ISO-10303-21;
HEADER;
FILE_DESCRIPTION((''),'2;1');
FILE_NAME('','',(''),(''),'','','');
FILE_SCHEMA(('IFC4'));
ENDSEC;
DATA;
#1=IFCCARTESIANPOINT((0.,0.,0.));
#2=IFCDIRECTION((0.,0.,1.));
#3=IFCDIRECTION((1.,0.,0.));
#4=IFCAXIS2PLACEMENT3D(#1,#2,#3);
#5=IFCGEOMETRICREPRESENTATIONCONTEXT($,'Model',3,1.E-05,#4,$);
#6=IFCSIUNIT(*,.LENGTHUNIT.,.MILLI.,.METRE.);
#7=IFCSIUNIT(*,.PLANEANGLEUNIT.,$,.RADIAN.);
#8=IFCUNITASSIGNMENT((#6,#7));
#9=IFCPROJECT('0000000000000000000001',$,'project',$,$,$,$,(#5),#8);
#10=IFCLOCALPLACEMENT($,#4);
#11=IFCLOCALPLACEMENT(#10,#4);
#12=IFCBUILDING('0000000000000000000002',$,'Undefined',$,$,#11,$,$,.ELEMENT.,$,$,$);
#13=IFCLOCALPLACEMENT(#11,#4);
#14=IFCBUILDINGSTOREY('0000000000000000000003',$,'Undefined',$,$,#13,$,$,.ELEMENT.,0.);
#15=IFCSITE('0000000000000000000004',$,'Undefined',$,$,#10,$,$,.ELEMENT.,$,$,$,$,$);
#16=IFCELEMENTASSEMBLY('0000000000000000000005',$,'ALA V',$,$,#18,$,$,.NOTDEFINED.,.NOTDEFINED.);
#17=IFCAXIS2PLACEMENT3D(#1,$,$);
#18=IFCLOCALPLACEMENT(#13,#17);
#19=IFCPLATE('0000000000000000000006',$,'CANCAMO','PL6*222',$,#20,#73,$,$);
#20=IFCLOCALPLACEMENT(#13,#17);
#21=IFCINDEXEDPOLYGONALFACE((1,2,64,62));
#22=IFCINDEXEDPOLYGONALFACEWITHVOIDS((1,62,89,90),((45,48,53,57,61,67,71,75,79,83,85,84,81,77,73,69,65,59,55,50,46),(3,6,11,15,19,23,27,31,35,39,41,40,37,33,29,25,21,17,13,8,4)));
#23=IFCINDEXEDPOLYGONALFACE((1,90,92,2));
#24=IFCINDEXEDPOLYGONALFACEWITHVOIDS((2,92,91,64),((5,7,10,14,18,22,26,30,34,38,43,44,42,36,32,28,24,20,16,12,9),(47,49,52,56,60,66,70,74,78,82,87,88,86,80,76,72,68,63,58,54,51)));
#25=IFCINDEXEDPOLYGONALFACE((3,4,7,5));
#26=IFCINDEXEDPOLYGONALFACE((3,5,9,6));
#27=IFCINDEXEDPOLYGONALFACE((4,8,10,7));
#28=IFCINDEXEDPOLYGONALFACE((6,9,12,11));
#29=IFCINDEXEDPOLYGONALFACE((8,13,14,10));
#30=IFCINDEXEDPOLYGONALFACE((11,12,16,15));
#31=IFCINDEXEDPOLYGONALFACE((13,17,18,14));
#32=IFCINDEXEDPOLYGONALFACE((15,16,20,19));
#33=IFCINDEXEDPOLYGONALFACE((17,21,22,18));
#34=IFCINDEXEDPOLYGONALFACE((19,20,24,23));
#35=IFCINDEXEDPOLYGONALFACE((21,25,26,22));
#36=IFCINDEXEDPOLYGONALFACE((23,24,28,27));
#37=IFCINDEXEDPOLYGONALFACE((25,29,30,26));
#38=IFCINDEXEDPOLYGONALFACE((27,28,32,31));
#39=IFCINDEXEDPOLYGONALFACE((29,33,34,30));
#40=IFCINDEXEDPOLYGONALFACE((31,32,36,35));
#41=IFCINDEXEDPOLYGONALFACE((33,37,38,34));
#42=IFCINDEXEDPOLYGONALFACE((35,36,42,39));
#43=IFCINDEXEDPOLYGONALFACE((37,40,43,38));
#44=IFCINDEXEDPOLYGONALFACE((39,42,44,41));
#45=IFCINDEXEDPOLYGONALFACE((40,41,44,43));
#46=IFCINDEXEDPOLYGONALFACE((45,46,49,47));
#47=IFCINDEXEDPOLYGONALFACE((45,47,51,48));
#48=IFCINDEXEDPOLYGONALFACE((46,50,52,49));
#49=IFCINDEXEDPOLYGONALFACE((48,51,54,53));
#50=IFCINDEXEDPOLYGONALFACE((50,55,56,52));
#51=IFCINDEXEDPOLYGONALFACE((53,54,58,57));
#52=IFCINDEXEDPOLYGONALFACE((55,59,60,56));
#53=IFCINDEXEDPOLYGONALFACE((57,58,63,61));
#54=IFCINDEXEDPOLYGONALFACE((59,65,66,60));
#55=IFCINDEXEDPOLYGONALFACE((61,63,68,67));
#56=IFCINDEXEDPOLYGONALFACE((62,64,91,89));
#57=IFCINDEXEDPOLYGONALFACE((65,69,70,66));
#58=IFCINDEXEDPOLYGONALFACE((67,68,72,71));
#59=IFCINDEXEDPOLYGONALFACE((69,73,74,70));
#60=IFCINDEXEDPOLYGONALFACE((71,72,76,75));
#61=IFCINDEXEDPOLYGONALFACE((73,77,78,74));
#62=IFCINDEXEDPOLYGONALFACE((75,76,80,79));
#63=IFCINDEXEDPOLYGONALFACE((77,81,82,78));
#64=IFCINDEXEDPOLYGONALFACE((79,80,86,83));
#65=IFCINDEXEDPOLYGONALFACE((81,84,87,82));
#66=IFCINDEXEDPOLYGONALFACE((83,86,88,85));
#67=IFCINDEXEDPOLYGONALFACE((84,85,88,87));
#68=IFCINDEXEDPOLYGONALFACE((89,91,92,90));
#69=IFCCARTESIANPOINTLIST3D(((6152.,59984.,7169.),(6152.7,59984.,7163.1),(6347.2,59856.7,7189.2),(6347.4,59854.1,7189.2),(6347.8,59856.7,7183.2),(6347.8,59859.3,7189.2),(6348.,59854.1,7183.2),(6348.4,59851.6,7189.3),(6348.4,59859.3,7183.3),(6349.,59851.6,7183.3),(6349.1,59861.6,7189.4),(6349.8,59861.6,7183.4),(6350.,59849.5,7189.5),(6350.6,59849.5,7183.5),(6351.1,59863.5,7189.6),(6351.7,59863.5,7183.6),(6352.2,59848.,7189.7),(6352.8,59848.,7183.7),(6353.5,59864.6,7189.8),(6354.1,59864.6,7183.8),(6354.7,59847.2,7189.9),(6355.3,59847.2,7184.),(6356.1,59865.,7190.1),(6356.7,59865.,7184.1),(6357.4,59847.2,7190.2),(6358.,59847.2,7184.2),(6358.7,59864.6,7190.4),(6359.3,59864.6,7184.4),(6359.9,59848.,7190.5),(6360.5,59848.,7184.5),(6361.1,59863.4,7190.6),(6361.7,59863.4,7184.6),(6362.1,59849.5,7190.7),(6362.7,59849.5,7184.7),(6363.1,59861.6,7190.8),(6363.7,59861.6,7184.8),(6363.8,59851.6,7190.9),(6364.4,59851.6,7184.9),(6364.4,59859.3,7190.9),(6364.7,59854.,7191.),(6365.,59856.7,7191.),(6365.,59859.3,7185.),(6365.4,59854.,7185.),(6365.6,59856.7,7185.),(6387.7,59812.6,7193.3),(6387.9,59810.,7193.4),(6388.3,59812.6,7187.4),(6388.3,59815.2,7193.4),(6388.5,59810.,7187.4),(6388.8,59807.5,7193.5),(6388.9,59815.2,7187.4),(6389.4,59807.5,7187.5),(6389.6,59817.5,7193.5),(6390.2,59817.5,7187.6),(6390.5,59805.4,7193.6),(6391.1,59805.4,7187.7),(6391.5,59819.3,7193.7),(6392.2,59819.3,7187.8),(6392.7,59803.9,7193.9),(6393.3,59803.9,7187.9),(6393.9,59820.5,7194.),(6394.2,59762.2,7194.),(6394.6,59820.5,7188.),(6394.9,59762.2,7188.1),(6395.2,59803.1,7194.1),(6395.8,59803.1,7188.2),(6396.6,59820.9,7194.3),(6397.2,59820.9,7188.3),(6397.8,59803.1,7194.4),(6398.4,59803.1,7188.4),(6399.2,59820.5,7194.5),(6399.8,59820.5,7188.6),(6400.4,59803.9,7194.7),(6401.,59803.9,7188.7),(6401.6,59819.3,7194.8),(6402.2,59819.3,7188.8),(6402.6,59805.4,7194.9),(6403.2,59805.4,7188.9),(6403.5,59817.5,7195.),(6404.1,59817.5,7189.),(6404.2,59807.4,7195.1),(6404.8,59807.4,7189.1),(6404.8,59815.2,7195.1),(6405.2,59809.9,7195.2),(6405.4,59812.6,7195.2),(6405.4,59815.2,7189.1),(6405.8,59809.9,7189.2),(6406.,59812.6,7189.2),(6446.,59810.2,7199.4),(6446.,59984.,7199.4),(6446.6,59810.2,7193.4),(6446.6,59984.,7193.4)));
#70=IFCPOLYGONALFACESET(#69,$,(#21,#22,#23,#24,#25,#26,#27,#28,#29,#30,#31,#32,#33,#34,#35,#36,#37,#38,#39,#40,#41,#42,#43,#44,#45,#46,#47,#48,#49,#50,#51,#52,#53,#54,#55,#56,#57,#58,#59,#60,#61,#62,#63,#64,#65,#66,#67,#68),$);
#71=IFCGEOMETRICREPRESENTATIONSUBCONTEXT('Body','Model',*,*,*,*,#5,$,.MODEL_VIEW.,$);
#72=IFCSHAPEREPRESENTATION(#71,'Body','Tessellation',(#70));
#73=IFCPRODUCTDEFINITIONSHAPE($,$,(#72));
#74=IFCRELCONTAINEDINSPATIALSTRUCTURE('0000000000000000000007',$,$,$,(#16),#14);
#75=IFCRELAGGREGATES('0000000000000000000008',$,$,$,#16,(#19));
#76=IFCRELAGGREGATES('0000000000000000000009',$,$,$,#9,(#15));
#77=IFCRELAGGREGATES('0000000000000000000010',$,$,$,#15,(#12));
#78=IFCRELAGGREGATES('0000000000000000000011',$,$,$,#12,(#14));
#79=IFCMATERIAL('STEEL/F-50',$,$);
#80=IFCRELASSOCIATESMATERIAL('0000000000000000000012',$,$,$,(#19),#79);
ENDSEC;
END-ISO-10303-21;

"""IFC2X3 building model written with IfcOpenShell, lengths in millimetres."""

from ifc_helpers import new_model, si_unit, frame, origin_with_axes, origin_2d_with_axis, place, context, subcontext, project, spatial, polyline, circle, outline, extrude, source, transform, mapped, material, element, aggregate, save


model = new_model("IFC2X3")

# Units and contexts
model_context = context("Model", 3, precision=1e-05, world=origin_with_axes())
body_context = subcontext(model_context, "Body", "Model", "MODEL_VIEW")
ifc_project = project(units=[si_unit("LENGTHUNIT", "METRE", prefix="MILLI"), si_unit("PLANEANGLEUNIT", "RADIAN")], contexts=[model_context])

# Site, building, storey
site_placement = place(None, origin_with_axes())
site = spatial("IfcSite", under=ifc_project, at=site_placement, Name="Undefined", CompositionType="ELEMENT")
building_placement = place(site_placement, origin_with_axes())
building = spatial("IfcBuilding", under=site, at=building_placement, Name="Undefined", CompositionType="ELEMENT")
storey_placement = place(building_placement, origin_with_axes())
storey = spatial("IfcBuildingStorey", under=building, at=storey_placement, Name="Undefined", CompositionType="ELEMENT", Elevation=0.0)

# Element assembly
assembly_1_placement = place(storey_placement, origin_with_axes())
assembly_1 = element("IfcElementAssembly", 1, at=assembly_1_placement, inside=storey, Name="ALA V", AssemblyPlace="NOTDEFINED", PredefinedType="NOTDEFINED")
ifc_material_1 = material(Name="STEEL/F-50")

# Plate, opening
plate_1_placement = place(assembly_1_placement, frame((6446.3, 59984.0, 7196.4), z_axis=(-0.102676, 0.0, 0.994715), x_axis=(-0.994715, 0.0, -0.102675)))
plate_1 = element("IfcPlate", 2, at=plate_1_placement, material=ifc_material_1, Name="CANCAMO", Description="PL6*222", context=body_context, shape_type="SweptSolid", body=[
    extrude(outline(polyline([(0.0, 0.0), (295.5, 0.0), (52.1, 221.8), (0.0, 173.8), (0.0, 0.0)])), frame((0.0, 0.0, -3.0), z_axis=(0.0, 0.0, 1.0), x_axis=(1.0, 0.0, 0.0)), (0.0, 0.0, 1.0), 6.0),
])
shared_shape_1 = source(origin_with_axes(), body_context, "Body", "SweptSolid", [
    extrude(circle(Radius=8.9, at=origin_2d_with_axis()), frame((0.0, -0.1, 0.0), z_axis=(0.0, 1.0, 0.0), x_axis=(1.0, 0.0, 0.0)), (0.0, 0.0, 1.0), 6.2),
])
opening_1_placement = place(assembly_1_placement, frame((6356.1, 59856.1, 7190.1), z_axis=(0.731384, 0.677774, 0.075494), x_axis=(0.674192, -0.73527, 0.069591)))
element("IfcOpeningElement", 3, at=opening_1_placement, cuts=plate_1, ObjectType="Opening", context=body_context, shape_type="MappedRepresentation", body=[
    mapped(shared_shape_1, transform((0.0, 0.0, 0.0))),
    mapped(shared_shape_1, transform((60.0, 0.0, 0.0))),
])

aggregate(assembly_1, [plate_1])

save(model, "model.ifc")
